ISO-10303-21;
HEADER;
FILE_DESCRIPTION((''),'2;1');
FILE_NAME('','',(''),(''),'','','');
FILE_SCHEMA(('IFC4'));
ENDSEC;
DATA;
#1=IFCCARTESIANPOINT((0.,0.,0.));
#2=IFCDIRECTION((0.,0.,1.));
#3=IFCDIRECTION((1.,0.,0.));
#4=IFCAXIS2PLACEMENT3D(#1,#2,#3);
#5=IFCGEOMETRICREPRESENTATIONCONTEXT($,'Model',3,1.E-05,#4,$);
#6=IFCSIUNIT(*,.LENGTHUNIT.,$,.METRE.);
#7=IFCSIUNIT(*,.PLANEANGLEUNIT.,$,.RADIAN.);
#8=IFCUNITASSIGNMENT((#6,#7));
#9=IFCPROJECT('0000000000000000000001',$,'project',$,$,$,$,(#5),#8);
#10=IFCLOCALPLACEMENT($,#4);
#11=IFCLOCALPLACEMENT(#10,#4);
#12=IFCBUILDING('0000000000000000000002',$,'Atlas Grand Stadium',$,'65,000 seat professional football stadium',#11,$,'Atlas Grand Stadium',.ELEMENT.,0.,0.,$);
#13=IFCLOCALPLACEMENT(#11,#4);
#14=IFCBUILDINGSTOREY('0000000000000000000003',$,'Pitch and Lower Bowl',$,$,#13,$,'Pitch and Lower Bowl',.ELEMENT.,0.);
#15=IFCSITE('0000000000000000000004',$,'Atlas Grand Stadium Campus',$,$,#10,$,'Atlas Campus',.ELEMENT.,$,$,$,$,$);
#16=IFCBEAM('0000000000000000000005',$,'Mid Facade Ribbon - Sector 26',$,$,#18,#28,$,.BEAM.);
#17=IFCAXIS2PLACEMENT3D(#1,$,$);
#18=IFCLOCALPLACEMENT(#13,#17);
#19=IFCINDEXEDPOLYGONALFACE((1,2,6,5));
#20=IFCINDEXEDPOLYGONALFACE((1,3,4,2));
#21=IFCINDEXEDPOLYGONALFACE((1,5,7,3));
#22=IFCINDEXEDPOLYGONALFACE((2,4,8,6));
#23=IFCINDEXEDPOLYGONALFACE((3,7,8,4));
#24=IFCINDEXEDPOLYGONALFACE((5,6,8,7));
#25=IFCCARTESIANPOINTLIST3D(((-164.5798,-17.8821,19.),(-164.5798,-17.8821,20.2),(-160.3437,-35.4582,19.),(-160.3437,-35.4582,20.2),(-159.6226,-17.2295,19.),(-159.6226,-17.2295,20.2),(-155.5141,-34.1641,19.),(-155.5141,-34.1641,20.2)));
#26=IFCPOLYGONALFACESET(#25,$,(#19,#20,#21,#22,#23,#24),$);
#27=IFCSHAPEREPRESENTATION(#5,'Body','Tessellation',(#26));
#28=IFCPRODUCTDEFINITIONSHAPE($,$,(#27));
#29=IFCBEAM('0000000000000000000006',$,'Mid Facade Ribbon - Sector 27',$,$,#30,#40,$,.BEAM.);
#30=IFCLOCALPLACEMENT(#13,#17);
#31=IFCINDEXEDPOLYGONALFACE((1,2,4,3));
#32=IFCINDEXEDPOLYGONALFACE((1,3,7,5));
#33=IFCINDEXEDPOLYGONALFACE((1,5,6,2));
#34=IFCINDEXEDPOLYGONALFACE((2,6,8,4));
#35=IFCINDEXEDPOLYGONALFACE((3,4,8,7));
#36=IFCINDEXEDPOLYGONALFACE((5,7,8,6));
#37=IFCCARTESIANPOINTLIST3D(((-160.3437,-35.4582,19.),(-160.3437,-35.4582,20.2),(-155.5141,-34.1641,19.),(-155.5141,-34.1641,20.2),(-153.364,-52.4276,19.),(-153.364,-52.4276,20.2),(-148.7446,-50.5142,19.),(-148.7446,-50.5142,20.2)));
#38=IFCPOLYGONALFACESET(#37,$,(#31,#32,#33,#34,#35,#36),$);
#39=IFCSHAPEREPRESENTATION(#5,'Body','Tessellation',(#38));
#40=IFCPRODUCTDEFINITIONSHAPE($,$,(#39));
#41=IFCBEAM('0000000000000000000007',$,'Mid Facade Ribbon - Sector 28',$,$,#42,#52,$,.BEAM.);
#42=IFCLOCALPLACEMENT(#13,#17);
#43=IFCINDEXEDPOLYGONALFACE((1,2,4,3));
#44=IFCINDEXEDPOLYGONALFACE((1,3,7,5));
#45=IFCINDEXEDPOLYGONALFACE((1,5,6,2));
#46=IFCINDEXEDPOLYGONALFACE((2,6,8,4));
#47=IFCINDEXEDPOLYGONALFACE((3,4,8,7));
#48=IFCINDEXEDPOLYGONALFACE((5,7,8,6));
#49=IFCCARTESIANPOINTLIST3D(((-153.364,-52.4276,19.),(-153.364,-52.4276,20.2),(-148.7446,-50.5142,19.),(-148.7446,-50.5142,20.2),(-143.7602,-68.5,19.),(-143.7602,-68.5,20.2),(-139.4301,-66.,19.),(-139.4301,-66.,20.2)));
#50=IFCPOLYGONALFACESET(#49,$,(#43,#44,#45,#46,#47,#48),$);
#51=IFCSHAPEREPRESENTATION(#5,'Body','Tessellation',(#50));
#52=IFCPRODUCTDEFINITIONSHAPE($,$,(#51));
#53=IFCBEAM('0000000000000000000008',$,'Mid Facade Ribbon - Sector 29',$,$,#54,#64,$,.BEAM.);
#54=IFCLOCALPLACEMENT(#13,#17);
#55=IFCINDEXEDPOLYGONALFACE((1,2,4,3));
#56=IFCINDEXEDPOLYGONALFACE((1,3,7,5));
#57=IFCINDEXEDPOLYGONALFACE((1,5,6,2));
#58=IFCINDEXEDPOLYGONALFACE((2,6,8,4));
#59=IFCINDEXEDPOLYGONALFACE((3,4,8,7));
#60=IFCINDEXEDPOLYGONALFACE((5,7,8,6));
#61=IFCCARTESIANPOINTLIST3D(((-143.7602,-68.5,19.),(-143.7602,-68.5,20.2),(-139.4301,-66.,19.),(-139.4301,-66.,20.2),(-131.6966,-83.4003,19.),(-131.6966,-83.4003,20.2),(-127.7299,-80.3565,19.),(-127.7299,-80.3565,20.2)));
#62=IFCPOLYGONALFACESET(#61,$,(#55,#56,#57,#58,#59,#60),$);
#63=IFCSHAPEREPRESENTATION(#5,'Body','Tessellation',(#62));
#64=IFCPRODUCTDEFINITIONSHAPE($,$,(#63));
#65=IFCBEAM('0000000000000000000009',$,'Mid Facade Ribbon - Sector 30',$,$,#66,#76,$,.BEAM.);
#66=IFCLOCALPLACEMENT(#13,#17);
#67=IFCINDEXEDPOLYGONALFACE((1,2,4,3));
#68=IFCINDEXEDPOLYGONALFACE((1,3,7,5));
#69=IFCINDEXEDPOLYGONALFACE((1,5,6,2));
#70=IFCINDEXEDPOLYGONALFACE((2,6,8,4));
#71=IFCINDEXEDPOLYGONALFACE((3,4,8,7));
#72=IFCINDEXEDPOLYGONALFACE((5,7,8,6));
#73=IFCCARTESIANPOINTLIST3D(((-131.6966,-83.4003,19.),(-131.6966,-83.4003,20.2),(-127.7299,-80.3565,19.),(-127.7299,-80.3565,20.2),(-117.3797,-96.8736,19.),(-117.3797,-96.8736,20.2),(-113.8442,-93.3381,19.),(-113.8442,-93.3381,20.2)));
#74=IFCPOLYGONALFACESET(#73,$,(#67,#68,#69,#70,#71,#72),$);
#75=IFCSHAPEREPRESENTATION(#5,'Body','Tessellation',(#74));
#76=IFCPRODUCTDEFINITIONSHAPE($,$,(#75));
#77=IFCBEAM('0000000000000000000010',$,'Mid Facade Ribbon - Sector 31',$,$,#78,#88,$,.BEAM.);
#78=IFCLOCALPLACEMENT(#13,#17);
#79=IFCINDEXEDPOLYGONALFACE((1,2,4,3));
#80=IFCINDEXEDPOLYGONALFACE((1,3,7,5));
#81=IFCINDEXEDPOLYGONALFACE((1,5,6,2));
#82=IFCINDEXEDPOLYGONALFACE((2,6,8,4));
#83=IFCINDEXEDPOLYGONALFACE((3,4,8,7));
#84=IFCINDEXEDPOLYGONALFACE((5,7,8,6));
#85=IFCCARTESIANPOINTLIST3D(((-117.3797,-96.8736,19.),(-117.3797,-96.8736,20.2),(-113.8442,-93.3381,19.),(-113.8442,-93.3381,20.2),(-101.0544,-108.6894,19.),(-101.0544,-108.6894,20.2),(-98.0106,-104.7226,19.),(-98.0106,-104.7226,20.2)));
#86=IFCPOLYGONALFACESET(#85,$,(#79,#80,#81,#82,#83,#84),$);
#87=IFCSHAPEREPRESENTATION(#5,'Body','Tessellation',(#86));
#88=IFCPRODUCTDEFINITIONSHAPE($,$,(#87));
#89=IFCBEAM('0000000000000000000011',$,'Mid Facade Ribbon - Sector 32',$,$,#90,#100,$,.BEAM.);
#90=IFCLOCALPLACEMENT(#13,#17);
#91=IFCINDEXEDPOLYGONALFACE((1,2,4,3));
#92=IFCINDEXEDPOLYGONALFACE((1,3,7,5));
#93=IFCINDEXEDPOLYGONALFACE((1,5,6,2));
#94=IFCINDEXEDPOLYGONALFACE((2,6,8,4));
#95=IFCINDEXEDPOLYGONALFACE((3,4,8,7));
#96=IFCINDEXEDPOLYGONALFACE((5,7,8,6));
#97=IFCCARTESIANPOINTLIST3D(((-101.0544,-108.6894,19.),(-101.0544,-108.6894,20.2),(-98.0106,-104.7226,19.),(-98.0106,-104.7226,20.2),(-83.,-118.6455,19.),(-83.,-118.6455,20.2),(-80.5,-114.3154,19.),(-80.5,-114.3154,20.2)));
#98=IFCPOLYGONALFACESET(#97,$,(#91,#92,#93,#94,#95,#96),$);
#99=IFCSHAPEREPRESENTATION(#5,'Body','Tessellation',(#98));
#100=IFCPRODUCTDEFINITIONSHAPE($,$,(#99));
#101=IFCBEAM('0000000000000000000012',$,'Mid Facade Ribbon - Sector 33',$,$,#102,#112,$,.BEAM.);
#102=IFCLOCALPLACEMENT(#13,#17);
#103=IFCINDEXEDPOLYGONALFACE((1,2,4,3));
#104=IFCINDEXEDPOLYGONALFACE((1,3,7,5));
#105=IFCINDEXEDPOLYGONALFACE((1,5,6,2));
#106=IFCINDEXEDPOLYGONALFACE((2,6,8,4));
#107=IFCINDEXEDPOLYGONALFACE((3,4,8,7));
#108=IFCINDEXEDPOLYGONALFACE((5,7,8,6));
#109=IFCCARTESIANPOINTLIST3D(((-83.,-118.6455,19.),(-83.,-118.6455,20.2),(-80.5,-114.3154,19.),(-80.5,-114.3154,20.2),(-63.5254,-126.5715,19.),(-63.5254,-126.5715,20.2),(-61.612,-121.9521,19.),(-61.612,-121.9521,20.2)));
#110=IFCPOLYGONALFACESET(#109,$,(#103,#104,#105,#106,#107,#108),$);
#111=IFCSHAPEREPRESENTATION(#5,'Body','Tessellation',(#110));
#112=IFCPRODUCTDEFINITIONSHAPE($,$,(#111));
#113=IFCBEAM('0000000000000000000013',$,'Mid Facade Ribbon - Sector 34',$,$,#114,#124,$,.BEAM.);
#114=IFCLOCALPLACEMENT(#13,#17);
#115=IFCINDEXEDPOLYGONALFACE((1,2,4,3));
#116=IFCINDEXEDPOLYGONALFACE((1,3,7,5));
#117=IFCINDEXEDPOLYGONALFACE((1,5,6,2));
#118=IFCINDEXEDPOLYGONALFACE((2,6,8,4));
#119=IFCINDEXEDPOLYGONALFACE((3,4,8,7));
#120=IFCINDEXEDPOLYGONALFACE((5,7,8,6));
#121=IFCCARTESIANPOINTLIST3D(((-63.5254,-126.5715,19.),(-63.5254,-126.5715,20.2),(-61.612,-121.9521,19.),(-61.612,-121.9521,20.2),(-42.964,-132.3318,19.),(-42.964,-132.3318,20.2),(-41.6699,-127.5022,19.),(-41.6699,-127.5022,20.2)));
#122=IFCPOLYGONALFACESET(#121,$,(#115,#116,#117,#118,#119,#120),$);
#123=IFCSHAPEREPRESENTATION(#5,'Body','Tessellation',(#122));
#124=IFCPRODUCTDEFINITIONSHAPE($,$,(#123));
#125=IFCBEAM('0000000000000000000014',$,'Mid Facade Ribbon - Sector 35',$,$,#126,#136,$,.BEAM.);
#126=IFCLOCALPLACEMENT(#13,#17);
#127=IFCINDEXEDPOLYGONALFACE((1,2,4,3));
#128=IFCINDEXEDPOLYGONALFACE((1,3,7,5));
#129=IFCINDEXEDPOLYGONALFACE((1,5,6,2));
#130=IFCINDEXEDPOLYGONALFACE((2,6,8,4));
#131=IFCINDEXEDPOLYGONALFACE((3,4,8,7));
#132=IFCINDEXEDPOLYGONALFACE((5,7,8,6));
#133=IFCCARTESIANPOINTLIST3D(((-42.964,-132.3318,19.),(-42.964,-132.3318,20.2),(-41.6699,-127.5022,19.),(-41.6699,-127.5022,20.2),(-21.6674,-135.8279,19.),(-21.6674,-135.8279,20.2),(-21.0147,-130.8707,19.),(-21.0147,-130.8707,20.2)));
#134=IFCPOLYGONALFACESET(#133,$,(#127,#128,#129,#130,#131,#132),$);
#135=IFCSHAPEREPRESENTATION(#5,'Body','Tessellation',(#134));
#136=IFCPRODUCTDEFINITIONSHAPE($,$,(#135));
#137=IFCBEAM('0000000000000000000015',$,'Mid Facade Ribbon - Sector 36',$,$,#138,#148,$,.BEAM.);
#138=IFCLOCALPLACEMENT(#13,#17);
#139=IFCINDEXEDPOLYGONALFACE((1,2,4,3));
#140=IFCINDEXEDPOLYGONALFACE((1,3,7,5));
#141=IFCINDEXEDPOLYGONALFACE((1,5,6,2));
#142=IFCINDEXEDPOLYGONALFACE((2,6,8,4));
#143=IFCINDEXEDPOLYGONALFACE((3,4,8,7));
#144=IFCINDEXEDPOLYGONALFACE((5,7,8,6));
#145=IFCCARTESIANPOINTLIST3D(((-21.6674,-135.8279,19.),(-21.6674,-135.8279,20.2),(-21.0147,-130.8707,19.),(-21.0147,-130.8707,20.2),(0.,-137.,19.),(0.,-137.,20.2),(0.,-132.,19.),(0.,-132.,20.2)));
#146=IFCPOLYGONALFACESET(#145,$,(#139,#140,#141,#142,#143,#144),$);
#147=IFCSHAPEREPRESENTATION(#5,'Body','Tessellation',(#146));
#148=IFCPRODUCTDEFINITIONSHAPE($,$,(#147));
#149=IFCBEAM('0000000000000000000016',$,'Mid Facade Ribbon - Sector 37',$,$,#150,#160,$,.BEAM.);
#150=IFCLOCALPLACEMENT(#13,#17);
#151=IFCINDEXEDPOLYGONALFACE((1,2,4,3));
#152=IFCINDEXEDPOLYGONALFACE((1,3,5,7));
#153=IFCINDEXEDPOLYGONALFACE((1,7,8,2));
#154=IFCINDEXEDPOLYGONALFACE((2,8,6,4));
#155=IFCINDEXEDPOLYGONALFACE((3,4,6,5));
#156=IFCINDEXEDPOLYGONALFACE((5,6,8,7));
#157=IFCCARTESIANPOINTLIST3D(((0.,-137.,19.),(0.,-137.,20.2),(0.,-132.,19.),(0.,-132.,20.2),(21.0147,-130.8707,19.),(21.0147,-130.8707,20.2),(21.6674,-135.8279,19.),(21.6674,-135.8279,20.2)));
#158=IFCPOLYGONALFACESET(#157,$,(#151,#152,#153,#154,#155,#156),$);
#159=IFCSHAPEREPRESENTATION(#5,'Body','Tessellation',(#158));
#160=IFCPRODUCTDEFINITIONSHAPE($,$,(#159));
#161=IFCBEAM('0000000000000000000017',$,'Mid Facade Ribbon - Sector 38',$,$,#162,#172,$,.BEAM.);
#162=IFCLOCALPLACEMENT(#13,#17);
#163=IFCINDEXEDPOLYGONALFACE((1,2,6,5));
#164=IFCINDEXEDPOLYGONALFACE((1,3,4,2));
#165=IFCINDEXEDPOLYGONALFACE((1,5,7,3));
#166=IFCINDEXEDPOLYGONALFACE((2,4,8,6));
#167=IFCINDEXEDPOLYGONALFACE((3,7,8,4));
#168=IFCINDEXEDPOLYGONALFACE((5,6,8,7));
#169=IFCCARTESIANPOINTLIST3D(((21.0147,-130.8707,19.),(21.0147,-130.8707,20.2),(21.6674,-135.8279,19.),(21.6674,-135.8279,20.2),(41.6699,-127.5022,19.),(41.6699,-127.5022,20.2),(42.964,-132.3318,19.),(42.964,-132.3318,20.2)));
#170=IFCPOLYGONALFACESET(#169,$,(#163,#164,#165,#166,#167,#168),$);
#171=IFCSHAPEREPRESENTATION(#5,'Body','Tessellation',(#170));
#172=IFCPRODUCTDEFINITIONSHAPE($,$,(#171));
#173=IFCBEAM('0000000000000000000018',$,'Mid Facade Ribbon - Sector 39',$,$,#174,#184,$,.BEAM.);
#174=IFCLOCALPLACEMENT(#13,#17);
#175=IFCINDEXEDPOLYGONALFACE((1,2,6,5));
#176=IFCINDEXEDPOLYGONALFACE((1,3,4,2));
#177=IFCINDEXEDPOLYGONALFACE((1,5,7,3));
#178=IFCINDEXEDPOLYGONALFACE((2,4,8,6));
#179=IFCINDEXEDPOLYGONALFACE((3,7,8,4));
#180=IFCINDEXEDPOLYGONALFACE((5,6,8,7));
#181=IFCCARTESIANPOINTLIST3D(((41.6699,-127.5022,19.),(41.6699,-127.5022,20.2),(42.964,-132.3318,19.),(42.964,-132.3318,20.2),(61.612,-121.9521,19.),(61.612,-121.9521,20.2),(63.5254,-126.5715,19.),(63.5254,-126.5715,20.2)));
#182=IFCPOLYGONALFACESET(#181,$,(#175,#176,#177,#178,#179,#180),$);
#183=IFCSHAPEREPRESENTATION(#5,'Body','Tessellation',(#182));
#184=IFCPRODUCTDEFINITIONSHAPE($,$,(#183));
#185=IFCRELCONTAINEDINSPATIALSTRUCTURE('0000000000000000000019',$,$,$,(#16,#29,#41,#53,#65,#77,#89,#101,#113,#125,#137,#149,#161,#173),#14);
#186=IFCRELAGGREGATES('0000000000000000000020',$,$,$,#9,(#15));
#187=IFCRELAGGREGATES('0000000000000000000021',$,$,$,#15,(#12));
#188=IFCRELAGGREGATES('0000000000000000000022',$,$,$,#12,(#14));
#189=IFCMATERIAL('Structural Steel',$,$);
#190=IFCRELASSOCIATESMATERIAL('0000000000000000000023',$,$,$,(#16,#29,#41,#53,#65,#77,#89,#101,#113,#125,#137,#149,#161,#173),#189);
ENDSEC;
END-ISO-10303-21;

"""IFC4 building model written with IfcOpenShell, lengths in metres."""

from ifc_helpers import new_model, si_unit, frame, origin_with_axes, place, context, project, spatial, polyline, outline, extrude, material, element, save


model = new_model("IFC4")

# Units and contexts
model_context = context("Model", 3, precision=1e-05, world=origin_with_axes())
ifc_project = project(units=[si_unit("LENGTHUNIT", "METRE"), si_unit("PLANEANGLEUNIT", "RADIAN")], contexts=[model_context])

# Site, building, storey
site_placement = place(None, origin_with_axes())
site = spatial("IfcSite", under=ifc_project, at=site_placement, Name="Atlas Grand Stadium Campus", LongName="Atlas Campus", CompositionType="ELEMENT")
building_placement = place(site_placement, origin_with_axes())
building = spatial("IfcBuilding", under=site, at=building_placement, Name="Atlas Grand Stadium", ObjectType="65,000 seat professional football stadium", LongName="Atlas Grand Stadium", CompositionType="ELEMENT", ElevationOfRefHeight=0.0, ElevationOfTerrain=0.0)
storey_placement = place(building_placement, origin_with_axes())
storey = spatial("IfcBuildingStorey", under=building, at=storey_placement, Name="Pitch and Lower Bowl", LongName="Pitch and Lower Bowl", CompositionType="ELEMENT", Elevation=0.0)

# Beams
ifc_material = material(Name="Structural Steel")
beam_1_placement = place(storey_placement, frame((0.0, 0.0, 19.0), z_axis=(0.0, 0.0, 1.0), x_axis=(1.0, 0.0, 0.0)))
element("IfcBeam", 1, at=beam_1_placement, inside=storey, material=ifc_material, Name="Mid Facade Ribbon - Sector 26", PredefinedType="BEAM", context=model_context, shape_type="SweptSolid", body=[
    extrude(outline(polyline([(-164.5798, -17.8821), (-160.3437, -35.4582), (-155.5141, -34.1641), (-159.6226, -17.2295), (-164.5798, -17.8821)])), origin_with_axes(), (0.0, 0.0, 1.0), 1.2),
])
beam_2_placement = place(storey_placement, frame((0.0, 0.0, 19.0), z_axis=(0.0, 0.0, 1.0), x_axis=(1.0, 0.0, 0.0)))
element("IfcBeam", 2, at=beam_2_placement, inside=storey, material=ifc_material, Name="Mid Facade Ribbon - Sector 27", PredefinedType="BEAM", context=model_context, shape_type="SweptSolid", body=[
    extrude(outline(polyline([(-160.3437, -35.4582), (-153.364, -52.4276), (-148.7446, -50.5142), (-155.5141, -34.1641), (-160.3437, -35.4582)])), origin_with_axes(), (0.0, 0.0, 1.0), 1.2),
])
beam_3_placement = place(storey_placement, frame((0.0, 0.0, 19.0), z_axis=(0.0, 0.0, 1.0), x_axis=(1.0, 0.0, 0.0)))
element("IfcBeam", 3, at=beam_3_placement, inside=storey, material=ifc_material, Name="Mid Facade Ribbon - Sector 28", PredefinedType="BEAM", context=model_context, shape_type="SweptSolid", body=[
    extrude(outline(polyline([(-153.364, -52.4276), (-143.7602, -68.5), (-139.4301, -66.0), (-148.7446, -50.5142), (-153.364, -52.4276)])), origin_with_axes(), (0.0, 0.0, 1.0), 1.2),
])
beam_4_placement = place(storey_placement, frame((0.0, 0.0, 19.0), z_axis=(0.0, 0.0, 1.0), x_axis=(1.0, 0.0, 0.0)))
element("IfcBeam", 4, at=beam_4_placement, inside=storey, material=ifc_material, Name="Mid Facade Ribbon - Sector 29", PredefinedType="BEAM", context=model_context, shape_type="SweptSolid", body=[
    extrude(outline(polyline([(-143.7602, -68.5), (-131.6967, -83.4003), (-127.7299, -80.3565), (-139.4301, -66.0), (-143.7602, -68.5)])), origin_with_axes(), (0.0, 0.0, 1.0), 1.2),
])
beam_5_placement = place(storey_placement, frame((0.0, 0.0, 19.0), z_axis=(0.0, 0.0, 1.0), x_axis=(1.0, 0.0, 0.0)))
element("IfcBeam", 5, at=beam_5_placement, inside=storey, material=ifc_material, Name="Mid Facade Ribbon - Sector 30", PredefinedType="BEAM", context=model_context, shape_type="SweptSolid", body=[
    extrude(outline(polyline([(-131.6967, -83.4003), (-117.3797, -96.8736), (-113.8442, -93.3381), (-127.7299, -80.3565), (-131.6967, -83.4003)])), origin_with_axes(), (0.0, 0.0, 1.0), 1.2),
])
beam_6_placement = place(storey_placement, frame((0.0, 0.0, 19.0), z_axis=(0.0, 0.0, 1.0), x_axis=(1.0, 0.0, 0.0)))
element("IfcBeam", 6, at=beam_6_placement, inside=storey, material=ifc_material, Name="Mid Facade Ribbon - Sector 31", PredefinedType="BEAM", context=model_context, shape_type="SweptSolid", body=[
    extrude(outline(polyline([(-117.3797, -96.8736), (-101.0544, -108.6894), (-98.0106, -104.7226), (-113.8442, -93.3381), (-117.3797, -96.8736)])), origin_with_axes(), (0.0, 0.0, 1.0), 1.2),
])
beam_7_placement = place(storey_placement, frame((0.0, 0.0, 19.0), z_axis=(0.0, 0.0, 1.0), x_axis=(1.0, 0.0, 0.0)))
element("IfcBeam", 7, at=beam_7_placement, inside=storey, material=ifc_material, Name="Mid Facade Ribbon - Sector 32", PredefinedType="BEAM", context=model_context, shape_type="SweptSolid", body=[
    extrude(outline(polyline([(-101.0544, -108.6894), (-83.0, -118.6455), (-80.5, -114.3153), (-98.0106, -104.7226), (-101.0544, -108.6894)])), origin_with_axes(), (0.0, 0.0, 1.0), 1.2),
])
beam_8_placement = place(storey_placement, frame((0.0, 0.0, 19.0), z_axis=(0.0, 0.0, 1.0), x_axis=(1.0, 0.0, 0.0)))
element("IfcBeam", 8, at=beam_8_placement, inside=storey, material=ifc_material, Name="Mid Facade Ribbon - Sector 33", PredefinedType="BEAM", context=model_context, shape_type="SweptSolid", body=[
    extrude(outline(polyline([(-83.0, -118.6455), (-63.5254, -126.5715), (-61.612, -121.9521), (-80.5, -114.3153), (-83.0, -118.6455)])), origin_with_axes(), (0.0, 0.0, 1.0), 1.2),
])
beam_9_placement = place(storey_placement, frame((0.0, 0.0, 19.0), z_axis=(0.0, 0.0, 1.0), x_axis=(1.0, 0.0, 0.0)))
element("IfcBeam", 9, at=beam_9_placement, inside=storey, material=ifc_material, Name="Mid Facade Ribbon - Sector 34", PredefinedType="BEAM", context=model_context, shape_type="SweptSolid", body=[
    extrude(outline(polyline([(-63.5254, -126.5715), (-42.964, -132.3318), (-41.6699, -127.5022), (-61.612, -121.9521), (-63.5254, -126.5715)])), origin_with_axes(), (0.0, 0.0, 1.0), 1.2),
])
beam_10_placement = place(storey_placement, frame((0.0, 0.0, 19.0), z_axis=(0.0, 0.0, 1.0), x_axis=(1.0, 0.0, 0.0)))
element("IfcBeam", 10, at=beam_10_placement, inside=storey, material=ifc_material, Name="Mid Facade Ribbon - Sector 35", PredefinedType="BEAM", context=model_context, shape_type="SweptSolid", body=[
    extrude(outline(polyline([(-42.964, -132.3318), (-21.6673, -135.8279), (-21.0147, -130.8707), (-41.6699, -127.5022), (-42.964, -132.3318)])), origin_with_axes(), (0.0, 0.0, 1.0), 1.2),
])
beam_11_placement = place(storey_placement, frame((0.0, 0.0, 19.0), z_axis=(0.0, 0.0, 1.0), x_axis=(1.0, 0.0, 0.0)))
element("IfcBeam", 11, at=beam_11_placement, inside=storey, material=ifc_material, Name="Mid Facade Ribbon - Sector 36", PredefinedType="BEAM", context=model_context, shape_type="SweptSolid", body=[
    extrude(outline(polyline([(-21.6673, -135.8279), (0.0, -137.0), (0.0, -132.0), (-21.0147, -130.8707), (-21.6673, -135.8279)])), origin_with_axes(), (0.0, 0.0, 1.0), 1.2),
])
beam_12_placement = place(storey_placement, frame((0.0, 0.0, 19.0), z_axis=(0.0, 0.0, 1.0), x_axis=(1.0, 0.0, 0.0)))
element("IfcBeam", 12, at=beam_12_placement, inside=storey, material=ifc_material, Name="Mid Facade Ribbon - Sector 37", PredefinedType="BEAM", context=model_context, shape_type="SweptSolid", body=[
    extrude(outline(polyline([(0.0, -137.0), (21.6673, -135.8279), (21.0147, -130.8707), (0.0, -132.0), (0.0, -137.0)])), origin_with_axes(), (0.0, 0.0, 1.0), 1.2),
])
beam_13_placement = place(storey_placement, frame((0.0, 0.0, 19.0), z_axis=(0.0, 0.0, 1.0), x_axis=(1.0, 0.0, 0.0)))
element("IfcBeam", 13, at=beam_13_placement, inside=storey, material=ifc_material, Name="Mid Facade Ribbon - Sector 38", PredefinedType="BEAM", context=model_context, shape_type="SweptSolid", body=[
    extrude(outline(polyline([(21.6673, -135.8279), (42.964, -132.3318), (41.6699, -127.5022), (21.0147, -130.8707), (21.6673, -135.8279)])), origin_with_axes(), (0.0, 0.0, 1.0), 1.2),
])
beam_14_placement = place(storey_placement, frame((0.0, 0.0, 19.0), z_axis=(0.0, 0.0, 1.0), x_axis=(1.0, 0.0, 0.0)))
element("IfcBeam", 14, at=beam_14_placement, inside=storey, material=ifc_material, Name="Mid Facade Ribbon - Sector 39", PredefinedType="BEAM", context=model_context, shape_type="SweptSolid", body=[
    extrude(outline(polyline([(42.964, -132.3318), (63.5254, -126.5715), (61.612, -121.9521), (41.6699, -127.5022), (42.964, -132.3318)])), origin_with_axes(), (0.0, 0.0, 1.0), 1.2),
])

save(model, "model.ifc")
